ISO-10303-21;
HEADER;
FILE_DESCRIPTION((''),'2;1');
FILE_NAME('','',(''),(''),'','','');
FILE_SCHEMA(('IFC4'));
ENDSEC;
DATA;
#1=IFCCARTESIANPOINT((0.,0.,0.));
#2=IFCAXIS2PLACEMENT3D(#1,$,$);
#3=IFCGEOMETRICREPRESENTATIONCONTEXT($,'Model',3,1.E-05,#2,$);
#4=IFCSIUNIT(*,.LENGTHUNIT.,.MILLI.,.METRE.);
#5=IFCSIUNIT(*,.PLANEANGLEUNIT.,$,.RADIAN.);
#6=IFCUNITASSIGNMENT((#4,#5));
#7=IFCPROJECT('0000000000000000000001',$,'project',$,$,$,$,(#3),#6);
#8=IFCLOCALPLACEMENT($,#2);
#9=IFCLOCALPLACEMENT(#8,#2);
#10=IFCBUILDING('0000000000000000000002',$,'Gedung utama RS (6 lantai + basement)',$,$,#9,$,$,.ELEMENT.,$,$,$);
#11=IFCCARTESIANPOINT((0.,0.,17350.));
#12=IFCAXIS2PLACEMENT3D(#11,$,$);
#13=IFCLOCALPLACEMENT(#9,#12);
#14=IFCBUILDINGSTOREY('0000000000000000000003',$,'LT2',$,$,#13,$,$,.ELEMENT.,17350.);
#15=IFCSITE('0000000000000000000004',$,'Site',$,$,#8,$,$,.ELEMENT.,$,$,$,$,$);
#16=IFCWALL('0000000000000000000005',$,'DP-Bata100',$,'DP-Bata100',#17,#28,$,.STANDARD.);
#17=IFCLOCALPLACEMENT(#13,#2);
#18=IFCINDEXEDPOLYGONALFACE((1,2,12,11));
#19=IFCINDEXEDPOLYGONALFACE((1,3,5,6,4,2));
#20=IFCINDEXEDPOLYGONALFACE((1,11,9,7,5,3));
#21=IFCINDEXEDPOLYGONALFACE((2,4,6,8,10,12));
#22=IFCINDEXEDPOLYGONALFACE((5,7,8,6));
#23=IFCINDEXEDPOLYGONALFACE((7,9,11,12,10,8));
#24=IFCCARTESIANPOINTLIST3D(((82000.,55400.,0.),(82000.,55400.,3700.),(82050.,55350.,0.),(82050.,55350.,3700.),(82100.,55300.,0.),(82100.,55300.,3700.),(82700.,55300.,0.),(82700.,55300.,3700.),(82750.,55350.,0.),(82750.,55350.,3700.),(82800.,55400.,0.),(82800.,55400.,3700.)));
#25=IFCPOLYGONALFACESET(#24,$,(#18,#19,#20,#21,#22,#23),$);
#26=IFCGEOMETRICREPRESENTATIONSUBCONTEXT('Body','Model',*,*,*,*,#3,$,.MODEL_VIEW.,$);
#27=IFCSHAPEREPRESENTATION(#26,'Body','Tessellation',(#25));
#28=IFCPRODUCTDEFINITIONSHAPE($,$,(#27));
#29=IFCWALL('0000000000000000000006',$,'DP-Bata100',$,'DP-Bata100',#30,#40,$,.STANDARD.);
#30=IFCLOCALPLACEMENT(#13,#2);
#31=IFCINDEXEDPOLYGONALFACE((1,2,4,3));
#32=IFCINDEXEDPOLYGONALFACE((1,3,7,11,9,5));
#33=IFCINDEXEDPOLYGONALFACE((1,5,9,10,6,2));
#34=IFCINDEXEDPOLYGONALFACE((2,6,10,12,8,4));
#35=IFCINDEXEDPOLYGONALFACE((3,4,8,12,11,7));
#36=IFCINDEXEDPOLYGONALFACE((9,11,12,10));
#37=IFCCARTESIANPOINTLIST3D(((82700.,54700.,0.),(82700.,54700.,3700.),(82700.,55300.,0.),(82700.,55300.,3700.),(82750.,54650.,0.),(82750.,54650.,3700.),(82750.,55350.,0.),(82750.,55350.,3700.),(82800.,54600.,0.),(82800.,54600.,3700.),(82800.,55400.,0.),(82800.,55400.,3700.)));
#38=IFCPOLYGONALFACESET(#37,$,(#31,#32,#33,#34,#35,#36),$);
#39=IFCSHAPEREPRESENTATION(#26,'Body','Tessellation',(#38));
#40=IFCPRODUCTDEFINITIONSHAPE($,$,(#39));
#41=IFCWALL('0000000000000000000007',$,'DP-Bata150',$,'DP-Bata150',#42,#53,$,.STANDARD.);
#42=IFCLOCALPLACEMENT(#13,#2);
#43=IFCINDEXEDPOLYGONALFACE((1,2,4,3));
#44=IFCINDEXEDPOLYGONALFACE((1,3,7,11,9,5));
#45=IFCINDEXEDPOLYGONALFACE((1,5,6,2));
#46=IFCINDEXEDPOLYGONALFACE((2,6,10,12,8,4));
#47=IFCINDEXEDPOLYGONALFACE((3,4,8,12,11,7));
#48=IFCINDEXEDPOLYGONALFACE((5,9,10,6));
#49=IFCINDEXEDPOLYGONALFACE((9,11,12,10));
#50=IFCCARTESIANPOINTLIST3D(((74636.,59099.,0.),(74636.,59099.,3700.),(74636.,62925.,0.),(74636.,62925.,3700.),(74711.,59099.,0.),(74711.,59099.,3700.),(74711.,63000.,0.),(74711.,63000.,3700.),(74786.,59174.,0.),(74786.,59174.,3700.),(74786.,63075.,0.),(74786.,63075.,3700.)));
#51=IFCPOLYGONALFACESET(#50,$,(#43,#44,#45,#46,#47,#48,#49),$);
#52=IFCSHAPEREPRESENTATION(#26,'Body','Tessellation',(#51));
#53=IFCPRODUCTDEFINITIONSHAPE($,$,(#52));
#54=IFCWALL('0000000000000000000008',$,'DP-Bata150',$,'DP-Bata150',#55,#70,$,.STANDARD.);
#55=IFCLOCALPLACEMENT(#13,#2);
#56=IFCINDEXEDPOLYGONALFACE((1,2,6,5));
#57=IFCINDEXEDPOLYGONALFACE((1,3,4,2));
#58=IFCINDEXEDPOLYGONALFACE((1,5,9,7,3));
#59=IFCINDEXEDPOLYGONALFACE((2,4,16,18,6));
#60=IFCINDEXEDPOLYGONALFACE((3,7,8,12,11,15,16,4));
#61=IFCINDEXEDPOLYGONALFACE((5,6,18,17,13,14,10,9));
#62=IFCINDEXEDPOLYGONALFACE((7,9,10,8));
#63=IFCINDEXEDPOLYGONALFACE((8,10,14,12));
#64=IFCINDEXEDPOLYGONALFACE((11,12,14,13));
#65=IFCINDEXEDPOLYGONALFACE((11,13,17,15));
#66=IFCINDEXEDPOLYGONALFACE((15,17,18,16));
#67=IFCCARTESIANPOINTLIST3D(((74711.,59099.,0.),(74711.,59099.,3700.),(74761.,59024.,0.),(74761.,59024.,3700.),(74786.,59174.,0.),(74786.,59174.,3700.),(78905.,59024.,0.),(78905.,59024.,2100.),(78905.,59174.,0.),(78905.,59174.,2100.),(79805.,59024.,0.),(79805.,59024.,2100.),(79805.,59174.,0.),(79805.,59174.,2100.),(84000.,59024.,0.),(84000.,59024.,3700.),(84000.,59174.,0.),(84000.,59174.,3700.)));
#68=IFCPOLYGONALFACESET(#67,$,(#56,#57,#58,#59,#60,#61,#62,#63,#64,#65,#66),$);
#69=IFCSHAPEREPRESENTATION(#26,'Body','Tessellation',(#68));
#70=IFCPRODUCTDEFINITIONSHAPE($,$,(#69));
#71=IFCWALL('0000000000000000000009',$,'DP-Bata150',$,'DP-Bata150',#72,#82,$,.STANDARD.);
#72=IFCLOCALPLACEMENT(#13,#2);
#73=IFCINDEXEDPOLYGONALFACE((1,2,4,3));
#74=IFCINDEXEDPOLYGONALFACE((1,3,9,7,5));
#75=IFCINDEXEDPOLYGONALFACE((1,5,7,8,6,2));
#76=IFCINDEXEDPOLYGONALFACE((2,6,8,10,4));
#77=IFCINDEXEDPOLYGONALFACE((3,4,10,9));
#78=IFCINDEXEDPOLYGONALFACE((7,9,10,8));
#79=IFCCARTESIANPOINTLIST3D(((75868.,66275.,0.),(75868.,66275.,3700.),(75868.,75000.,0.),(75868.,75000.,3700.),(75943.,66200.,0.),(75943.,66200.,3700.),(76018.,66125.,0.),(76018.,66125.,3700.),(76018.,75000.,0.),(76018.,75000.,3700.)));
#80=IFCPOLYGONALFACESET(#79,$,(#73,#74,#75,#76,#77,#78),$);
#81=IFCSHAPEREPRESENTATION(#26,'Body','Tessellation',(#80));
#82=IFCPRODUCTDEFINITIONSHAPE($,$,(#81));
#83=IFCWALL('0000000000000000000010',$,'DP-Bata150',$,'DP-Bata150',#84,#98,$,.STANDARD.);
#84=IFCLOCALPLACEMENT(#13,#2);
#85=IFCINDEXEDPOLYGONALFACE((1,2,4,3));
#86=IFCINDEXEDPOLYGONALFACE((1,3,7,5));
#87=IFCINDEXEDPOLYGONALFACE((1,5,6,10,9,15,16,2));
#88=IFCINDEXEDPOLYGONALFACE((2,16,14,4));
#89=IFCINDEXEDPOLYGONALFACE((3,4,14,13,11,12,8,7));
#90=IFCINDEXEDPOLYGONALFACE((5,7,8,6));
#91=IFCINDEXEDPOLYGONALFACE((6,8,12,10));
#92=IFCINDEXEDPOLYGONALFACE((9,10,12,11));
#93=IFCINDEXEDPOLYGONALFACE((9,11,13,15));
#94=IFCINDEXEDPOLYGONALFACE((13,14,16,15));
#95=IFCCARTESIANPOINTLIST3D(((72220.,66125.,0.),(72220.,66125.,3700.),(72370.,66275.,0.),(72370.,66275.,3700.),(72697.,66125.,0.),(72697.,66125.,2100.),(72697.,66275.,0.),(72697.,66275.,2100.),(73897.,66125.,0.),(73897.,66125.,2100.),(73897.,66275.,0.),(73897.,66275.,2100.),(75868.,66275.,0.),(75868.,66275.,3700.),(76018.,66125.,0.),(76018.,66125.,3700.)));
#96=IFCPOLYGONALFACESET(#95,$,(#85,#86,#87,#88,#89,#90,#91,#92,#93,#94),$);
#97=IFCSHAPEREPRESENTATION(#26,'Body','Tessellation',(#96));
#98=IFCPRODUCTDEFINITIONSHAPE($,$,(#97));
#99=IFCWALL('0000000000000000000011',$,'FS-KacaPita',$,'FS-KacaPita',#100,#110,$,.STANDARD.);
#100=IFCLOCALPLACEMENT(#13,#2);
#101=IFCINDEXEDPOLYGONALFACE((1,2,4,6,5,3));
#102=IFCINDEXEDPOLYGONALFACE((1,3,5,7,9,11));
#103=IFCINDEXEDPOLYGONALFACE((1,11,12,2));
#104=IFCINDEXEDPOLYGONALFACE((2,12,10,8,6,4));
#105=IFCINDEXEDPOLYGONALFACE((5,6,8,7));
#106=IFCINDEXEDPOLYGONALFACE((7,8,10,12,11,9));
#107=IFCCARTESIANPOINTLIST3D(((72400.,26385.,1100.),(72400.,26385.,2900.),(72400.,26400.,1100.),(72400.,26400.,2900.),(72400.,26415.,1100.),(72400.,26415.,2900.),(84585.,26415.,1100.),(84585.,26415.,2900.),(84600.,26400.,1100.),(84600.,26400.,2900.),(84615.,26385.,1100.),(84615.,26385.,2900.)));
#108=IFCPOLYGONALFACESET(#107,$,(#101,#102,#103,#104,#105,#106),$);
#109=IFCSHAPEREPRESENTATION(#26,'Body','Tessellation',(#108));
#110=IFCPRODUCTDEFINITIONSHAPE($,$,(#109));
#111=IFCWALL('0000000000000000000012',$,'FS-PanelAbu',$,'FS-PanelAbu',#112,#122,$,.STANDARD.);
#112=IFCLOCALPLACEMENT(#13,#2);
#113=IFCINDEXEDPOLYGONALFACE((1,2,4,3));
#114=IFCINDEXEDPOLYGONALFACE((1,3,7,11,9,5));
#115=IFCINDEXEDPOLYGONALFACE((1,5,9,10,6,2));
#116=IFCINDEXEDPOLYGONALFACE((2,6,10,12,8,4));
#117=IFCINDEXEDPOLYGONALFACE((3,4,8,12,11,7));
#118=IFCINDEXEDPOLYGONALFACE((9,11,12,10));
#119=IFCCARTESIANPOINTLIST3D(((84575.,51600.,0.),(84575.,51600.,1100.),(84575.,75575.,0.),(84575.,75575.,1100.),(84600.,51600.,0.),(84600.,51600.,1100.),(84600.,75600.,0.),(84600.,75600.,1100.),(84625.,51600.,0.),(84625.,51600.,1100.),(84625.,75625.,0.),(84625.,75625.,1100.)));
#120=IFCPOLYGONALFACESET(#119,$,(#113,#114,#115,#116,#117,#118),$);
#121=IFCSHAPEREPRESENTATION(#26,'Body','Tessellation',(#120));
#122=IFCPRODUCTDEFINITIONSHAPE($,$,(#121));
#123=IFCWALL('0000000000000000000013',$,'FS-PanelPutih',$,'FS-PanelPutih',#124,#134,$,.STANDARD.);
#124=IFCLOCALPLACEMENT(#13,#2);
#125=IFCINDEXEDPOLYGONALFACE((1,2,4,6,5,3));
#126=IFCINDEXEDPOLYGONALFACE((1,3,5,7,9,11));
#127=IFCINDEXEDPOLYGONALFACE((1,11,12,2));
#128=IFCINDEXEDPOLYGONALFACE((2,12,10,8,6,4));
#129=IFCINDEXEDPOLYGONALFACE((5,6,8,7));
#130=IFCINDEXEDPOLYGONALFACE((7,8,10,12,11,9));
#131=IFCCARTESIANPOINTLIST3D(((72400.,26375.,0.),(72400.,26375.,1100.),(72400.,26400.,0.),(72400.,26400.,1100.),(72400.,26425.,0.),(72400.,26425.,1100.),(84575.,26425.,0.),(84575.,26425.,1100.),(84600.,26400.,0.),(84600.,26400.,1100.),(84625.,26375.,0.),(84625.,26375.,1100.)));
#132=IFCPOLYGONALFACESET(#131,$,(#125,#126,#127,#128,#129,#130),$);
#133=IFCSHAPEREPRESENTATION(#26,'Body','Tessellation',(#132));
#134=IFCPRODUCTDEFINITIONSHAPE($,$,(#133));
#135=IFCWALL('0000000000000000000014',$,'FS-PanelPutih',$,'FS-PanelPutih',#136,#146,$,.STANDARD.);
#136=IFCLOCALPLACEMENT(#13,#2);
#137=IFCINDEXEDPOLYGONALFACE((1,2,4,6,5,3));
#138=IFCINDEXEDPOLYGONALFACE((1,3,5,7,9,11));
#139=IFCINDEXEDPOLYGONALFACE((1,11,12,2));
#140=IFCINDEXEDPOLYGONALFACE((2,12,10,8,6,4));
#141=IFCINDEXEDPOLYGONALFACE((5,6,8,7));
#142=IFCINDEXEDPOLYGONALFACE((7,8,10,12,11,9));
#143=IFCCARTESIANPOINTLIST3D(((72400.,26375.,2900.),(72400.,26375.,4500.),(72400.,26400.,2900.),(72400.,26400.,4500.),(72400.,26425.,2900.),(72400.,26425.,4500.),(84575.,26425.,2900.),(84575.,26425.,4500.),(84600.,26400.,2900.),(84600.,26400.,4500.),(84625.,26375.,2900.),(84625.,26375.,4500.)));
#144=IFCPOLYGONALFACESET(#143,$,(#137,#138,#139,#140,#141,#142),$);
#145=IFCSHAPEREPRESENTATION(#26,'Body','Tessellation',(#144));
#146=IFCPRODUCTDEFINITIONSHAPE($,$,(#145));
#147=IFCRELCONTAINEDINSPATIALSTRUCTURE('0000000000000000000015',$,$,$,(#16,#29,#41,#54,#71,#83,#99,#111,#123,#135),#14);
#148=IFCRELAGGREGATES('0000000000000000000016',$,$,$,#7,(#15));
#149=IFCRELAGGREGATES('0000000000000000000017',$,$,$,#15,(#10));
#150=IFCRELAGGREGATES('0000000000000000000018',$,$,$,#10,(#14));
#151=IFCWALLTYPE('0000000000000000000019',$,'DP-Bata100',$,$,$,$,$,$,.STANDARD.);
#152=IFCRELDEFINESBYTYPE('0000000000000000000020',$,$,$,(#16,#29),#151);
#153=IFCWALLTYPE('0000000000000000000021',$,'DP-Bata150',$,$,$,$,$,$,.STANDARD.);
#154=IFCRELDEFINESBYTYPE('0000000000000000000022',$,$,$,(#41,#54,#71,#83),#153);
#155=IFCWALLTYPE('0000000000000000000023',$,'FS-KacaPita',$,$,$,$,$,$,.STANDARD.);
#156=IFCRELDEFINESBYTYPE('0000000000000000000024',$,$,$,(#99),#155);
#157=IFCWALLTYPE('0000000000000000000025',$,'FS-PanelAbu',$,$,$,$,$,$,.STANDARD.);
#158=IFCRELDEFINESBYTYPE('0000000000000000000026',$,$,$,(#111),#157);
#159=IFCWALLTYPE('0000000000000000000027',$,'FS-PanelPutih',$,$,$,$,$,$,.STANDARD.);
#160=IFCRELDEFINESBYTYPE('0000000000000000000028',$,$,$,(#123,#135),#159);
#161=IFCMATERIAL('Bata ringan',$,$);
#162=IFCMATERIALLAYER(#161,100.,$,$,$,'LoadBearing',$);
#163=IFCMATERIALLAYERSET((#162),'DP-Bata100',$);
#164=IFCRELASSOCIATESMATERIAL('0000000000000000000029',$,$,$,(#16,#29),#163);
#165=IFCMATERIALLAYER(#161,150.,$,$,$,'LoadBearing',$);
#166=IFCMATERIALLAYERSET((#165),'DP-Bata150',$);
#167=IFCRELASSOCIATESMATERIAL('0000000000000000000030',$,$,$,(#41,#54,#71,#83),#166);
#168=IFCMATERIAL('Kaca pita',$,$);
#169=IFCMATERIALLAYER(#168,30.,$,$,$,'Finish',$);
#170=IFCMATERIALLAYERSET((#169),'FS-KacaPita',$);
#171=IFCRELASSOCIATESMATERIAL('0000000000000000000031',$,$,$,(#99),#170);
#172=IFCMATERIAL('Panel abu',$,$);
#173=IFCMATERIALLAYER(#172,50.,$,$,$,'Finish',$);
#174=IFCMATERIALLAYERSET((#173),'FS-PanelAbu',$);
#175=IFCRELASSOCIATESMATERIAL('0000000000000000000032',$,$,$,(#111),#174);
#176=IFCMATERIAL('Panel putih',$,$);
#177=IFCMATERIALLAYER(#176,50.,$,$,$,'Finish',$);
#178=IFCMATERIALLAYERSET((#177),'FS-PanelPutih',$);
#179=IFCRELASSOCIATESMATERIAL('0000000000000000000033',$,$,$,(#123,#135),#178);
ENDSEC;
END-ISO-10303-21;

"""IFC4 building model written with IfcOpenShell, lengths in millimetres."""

from ifc_helpers import new_model, si_unit, frame, frame_2d, origin, place, context, subcontext, project, spatial, polyline, rectangle, outline, extrude, material, layer, layer_set, layer_usage, type_object, element, save


model = new_model("IFC4")

# Units and contexts
model_context = context("Model", 3, precision=1e-05, world=origin())
body_context = subcontext(model_context, "Body", "Model", "MODEL_VIEW")
ifc_project = project(units=[si_unit("LENGTHUNIT", "METRE", prefix="MILLI"), si_unit("PLANEANGLEUNIT", "RADIAN")], contexts=[model_context])

# Site, building, storey
site_placement = place(None, origin())
site = spatial("IfcSite", under=ifc_project, at=site_placement, Name="Site", CompositionType="ELEMENT")
building_placement = place(site_placement, origin())
building = spatial("IfcBuilding", under=site, at=building_placement, Name="Gedung utama RS (6 lantai + basement)", CompositionType="ELEMENT")
storey_placement = place(building_placement, frame((0.0, 0.0, 17350.0)))
storey = spatial("IfcBuildingStorey", under=building, at=storey_placement, Name="LT2", CompositionType="ELEMENT", Elevation=17350.0)

# Shared definitions
ifc_material_1 = material(Name="Bata ringan")
ifc_layer_1 = layer(ifc_material_1, 100.0, Category="LoadBearing")
ifc_layer_set_1 = layer_set([ifc_layer_1], Name="DP-Bata100")
ifc_layer_usage_1 = layer_usage(ifc_layer_set_1, "AXIS2", "NEGATIVE", 50.0)
wall_type_1 = type_object("IfcWallType", Name="DP-Bata100", PredefinedType="STANDARD")

# Walls
for number, where, z_axis, x_axis, name in (
    (1, (82050.0, 55350.0, 0.0), (0.0, 0.0, 1.0), (1.0, 0.0, 0.0), "DP-Bata100"),
    (2, (82750.0, 55350.0, 0.0), (0.0, 0.0, 1.0), (0.0, -1.0, 0.0), "DP-Bata100"),
):
    element("IfcWall", number, at=place(storey_placement, frame(where, z_axis=z_axis, x_axis=x_axis)), inside=storey, type_object=wall_type_1, material=ifc_layer_usage_1, Name=name, ObjectType="DP-Bata100", PredefinedType="STANDARD", context=body_context, shape_type="SweptSolid", body=[
        extrude(outline(polyline([(50.0, -50.0), (0.0, 0.0), (-50.0, 50.0), (750.0, 50.0), (700.0, 0.0), (650.0, -50.0), (50.0, -50.0)])), origin(), (0.0, 0.0, 1.0), 3700.0),
    ])
ifc_layer_2 = layer(ifc_material_1, 150.0, Category="LoadBearing")
ifc_layer_set_2 = layer_set([ifc_layer_2], Name="DP-Bata150")
ifc_layer_usage_2 = layer_usage(ifc_layer_set_2, "AXIS2", "NEGATIVE", 75.0)
wall_type_2 = type_object("IfcWallType", Name="DP-Bata150", PredefinedType="STANDARD")
wall_1_placement = place(storey_placement, frame((74711.0, 63000.0, 0.0), z_axis=(0.0, 0.0, 1.0), x_axis=(0.0, -1.0, 0.0)))
element("IfcWall", 3, at=wall_1_placement, inside=storey, type_object=wall_type_2, material=ifc_layer_usage_2, Name="DP-Bata150", ObjectType="DP-Bata150", PredefinedType="STANDARD", context=body_context, shape_type="SweptSolid", body=[
    extrude(outline(polyline([(75.0, -75.0), (0.0, 0.0), (-75.0, 75.0), (3826.0, 75.0), (3901.0, 0.0), (3901.0, -75.0), (75.0, -75.0)])), origin(), (0.0, 0.0, 1.0), 3700.0),
])

# Wall, opening
wall_2_placement = place(storey_placement, frame((74711.0, 59099.0, 0.0), z_axis=(0.0, 0.0, 1.0), x_axis=(1.0, 0.0, 0.0)))
wall_2 = element("IfcWall", 4, at=wall_2_placement, inside=storey, type_object=wall_type_2, material=ifc_layer_usage_2, Name="DP-Bata150", ObjectType="DP-Bata150", PredefinedType="STANDARD", context=body_context, shape_type="SweptSolid", body=[
    extrude(outline(polyline([(50.0, -75.0), (0.0, 0.0), (75.0, 75.0), (9289.0, 75.0), (9289.0, -75.0), (50.0, -75.0)])), origin(), (0.0, 0.0, 1.0), 3700.0),
])
opening_1_placement = place(wall_2_placement, frame((4194.0, 0.0, 0.0), z_axis=(0.0, 0.0, 1.0), x_axis=(1.0, 0.0, 0.0)))
element("IfcOpeningElement", 5, at=opening_1_placement, cuts=wall_2, PredefinedType="OPENING", context=body_context, shape_type="SweptSolid", body=[
    extrude(rectangle(XDim=900.0, YDim=170.0, at=frame_2d((450.0, 0.0))), origin(), (0.0, 0.0, 1.0), 2100.0),
])

# Wall
wall_3_placement = place(storey_placement, frame((75943.0, 75000.0, 0.0), z_axis=(0.0, 0.0, 1.0), x_axis=(0.0, -1.0, 0.0)))
element("IfcWall", 6, at=wall_3_placement, inside=storey, type_object=wall_type_2, material=ifc_layer_usage_2, Name="DP-Bata150", ObjectType="DP-Bata150", PredefinedType="STANDARD", context=body_context, shape_type="SweptSolid", body=[
    extrude(outline(polyline([(0.0, -75.0), (0.0, 75.0), (8875.0, 75.0), (8800.0, 0.0), (8725.0, -75.0), (0.0, -75.0)])), origin(), (0.0, 0.0, 1.0), 3700.0),
])

# Wall, opening
wall_4_placement = place(storey_placement, frame((75943.0, 66200.0, 0.0), z_axis=(0.0, 0.0, 1.0), x_axis=(-1.0, 0.0, 0.0)))
wall_4 = element("IfcWall", 7, at=wall_4_placement, inside=storey, type_object=wall_type_2, material=ifc_layer_usage_2, Name="DP-Bata150", ObjectType="DP-Bata150", PredefinedType="STANDARD", context=body_context, shape_type="SweptSolid", body=[
    extrude(outline(polyline([(75.0, -75.0), (0.0, 0.0), (-75.0, 75.0), (3723.0, 75.0), (3648.0, 0.0), (3573.0, -75.0), (75.0, -75.0)])), origin(), (0.0, 0.0, 1.0), 3700.0),
])
opening_2_placement = place(wall_4_placement, frame((2046.0, 0.0, 0.0), z_axis=(0.0, 0.0, 1.0), x_axis=(1.0, 0.0, 0.0)))
element("IfcOpeningElement", 8, at=opening_2_placement, cuts=wall_4, PredefinedType="OPENING", context=body_context, shape_type="SweptSolid", body=[
    extrude(rectangle(XDim=1200.0, YDim=170.0, at=frame_2d((600.0, 0.0))), origin(), (0.0, 0.0, 1.0), 2100.0),
])

# Walls
ifc_material_2 = material(Name="Kaca pita")
ifc_layer_3 = layer(ifc_material_2, 30.0, Category="Finish")
ifc_layer_set_3 = layer_set([ifc_layer_3], Name="FS-KacaPita")
ifc_layer_usage_3 = layer_usage(ifc_layer_set_3, "AXIS2", "NEGATIVE", 15.0)
wall_type_3 = type_object("IfcWallType", Name="FS-KacaPita", PredefinedType="STANDARD")
wall_5_placement = place(storey_placement, frame((84600.0, 26400.0, 1100.0), z_axis=(0.0, 0.0, 1.0), x_axis=(-1.0, 0.0, 0.0)))
element("IfcWall", 9, at=wall_5_placement, inside=storey, type_object=wall_type_3, material=ifc_layer_usage_3, Name="FS-KacaPita", ObjectType="FS-KacaPita", PredefinedType="STANDARD", context=body_context, shape_type="SweptSolid", body=[
    extrude(outline(polyline([(15.0, -15.0), (0.0, 0.0), (-15.0, 15.0), (12200.0, 15.0), (12200.0, 0.0), (12200.0, -15.0), (15.0, -15.0)])), origin(), (0.0, 0.0, 1.0), 1800.0),
])
ifc_material_3 = material(Name="Panel abu")
ifc_layer_4 = layer(ifc_material_3, 50.0, Category="Finish")
ifc_layer_set_4 = layer_set([ifc_layer_4], Name="FS-PanelAbu")
ifc_layer_usage_4 = layer_usage(ifc_layer_set_4, "AXIS2", "NEGATIVE", 25.0)
wall_type_4 = type_object("IfcWallType", Name="FS-PanelAbu", PredefinedType="STANDARD")
wall_6_placement = place(storey_placement, frame((84600.0, 75600.0, 0.0), z_axis=(0.0, 0.0, 1.0), x_axis=(0.0, -1.0, 0.0)))
element("IfcWall", 10, at=wall_6_placement, inside=storey, type_object=wall_type_4, material=ifc_layer_usage_4, Name="FS-PanelAbu", ObjectType="FS-PanelAbu", PredefinedType="STANDARD", context=body_context, shape_type="SweptSolid", body=[
    extrude(outline(polyline([(25.0, -25.0), (0.0, 0.0), (-25.0, 25.0), (24000.0, 25.0), (24000.0, 0.0), (24000.0, -25.0), (25.0, -25.0)])), origin(), (0.0, 0.0, 1.0), 1100.0),
])
ifc_material_4 = material(Name="Panel putih")
ifc_layer_5 = layer(ifc_material_4, 50.0, Category="Finish")
ifc_layer_set_5 = layer_set([ifc_layer_5], Name="FS-PanelPutih")
ifc_layer_usage_5 = layer_usage(ifc_layer_set_5, "AXIS2", "NEGATIVE", 25.0)
wall_type_5 = type_object("IfcWallType", Name="FS-PanelPutih", PredefinedType="STANDARD")
wall_7_placement = place(storey_placement, frame((84600.0, 26400.0, 0.0), z_axis=(0.0, 0.0, 1.0), x_axis=(-1.0, 0.0, 0.0)))
element("IfcWall", 11, at=wall_7_placement, inside=storey, type_object=wall_type_5, material=ifc_layer_usage_5, Name="FS-PanelPutih", ObjectType="FS-PanelPutih", PredefinedType="STANDARD", context=body_context, shape_type="SweptSolid", body=[
    extrude(outline(polyline([(25.0, -25.0), (0.0, 0.0), (-25.0, 25.0), (12200.0, 25.0), (12200.0, 0.0), (12200.0, -25.0), (25.0, -25.0)])), origin(), (0.0, 0.0, 1.0), 1100.0),
])
wall_8_placement = place(storey_placement, frame((84600.0, 26400.0, 2900.0), z_axis=(0.0, 0.0, 1.0), x_axis=(-1.0, 0.0, 0.0)))
element("IfcWall", 12, at=wall_8_placement, inside=storey, type_object=wall_type_5, material=ifc_layer_usage_5, Name="FS-PanelPutih", ObjectType="FS-PanelPutih", PredefinedType="STANDARD", context=body_context, shape_type="SweptSolid", body=[
    extrude(outline(polyline([(25.0, -25.0), (0.0, 0.0), (-25.0, 25.0), (12200.0, 25.0), (12200.0, 0.0), (12200.0, -25.0), (25.0, -25.0)])), origin(), (0.0, 0.0, 1.0), 1600.0),
])

save(model, "model.ifc")
